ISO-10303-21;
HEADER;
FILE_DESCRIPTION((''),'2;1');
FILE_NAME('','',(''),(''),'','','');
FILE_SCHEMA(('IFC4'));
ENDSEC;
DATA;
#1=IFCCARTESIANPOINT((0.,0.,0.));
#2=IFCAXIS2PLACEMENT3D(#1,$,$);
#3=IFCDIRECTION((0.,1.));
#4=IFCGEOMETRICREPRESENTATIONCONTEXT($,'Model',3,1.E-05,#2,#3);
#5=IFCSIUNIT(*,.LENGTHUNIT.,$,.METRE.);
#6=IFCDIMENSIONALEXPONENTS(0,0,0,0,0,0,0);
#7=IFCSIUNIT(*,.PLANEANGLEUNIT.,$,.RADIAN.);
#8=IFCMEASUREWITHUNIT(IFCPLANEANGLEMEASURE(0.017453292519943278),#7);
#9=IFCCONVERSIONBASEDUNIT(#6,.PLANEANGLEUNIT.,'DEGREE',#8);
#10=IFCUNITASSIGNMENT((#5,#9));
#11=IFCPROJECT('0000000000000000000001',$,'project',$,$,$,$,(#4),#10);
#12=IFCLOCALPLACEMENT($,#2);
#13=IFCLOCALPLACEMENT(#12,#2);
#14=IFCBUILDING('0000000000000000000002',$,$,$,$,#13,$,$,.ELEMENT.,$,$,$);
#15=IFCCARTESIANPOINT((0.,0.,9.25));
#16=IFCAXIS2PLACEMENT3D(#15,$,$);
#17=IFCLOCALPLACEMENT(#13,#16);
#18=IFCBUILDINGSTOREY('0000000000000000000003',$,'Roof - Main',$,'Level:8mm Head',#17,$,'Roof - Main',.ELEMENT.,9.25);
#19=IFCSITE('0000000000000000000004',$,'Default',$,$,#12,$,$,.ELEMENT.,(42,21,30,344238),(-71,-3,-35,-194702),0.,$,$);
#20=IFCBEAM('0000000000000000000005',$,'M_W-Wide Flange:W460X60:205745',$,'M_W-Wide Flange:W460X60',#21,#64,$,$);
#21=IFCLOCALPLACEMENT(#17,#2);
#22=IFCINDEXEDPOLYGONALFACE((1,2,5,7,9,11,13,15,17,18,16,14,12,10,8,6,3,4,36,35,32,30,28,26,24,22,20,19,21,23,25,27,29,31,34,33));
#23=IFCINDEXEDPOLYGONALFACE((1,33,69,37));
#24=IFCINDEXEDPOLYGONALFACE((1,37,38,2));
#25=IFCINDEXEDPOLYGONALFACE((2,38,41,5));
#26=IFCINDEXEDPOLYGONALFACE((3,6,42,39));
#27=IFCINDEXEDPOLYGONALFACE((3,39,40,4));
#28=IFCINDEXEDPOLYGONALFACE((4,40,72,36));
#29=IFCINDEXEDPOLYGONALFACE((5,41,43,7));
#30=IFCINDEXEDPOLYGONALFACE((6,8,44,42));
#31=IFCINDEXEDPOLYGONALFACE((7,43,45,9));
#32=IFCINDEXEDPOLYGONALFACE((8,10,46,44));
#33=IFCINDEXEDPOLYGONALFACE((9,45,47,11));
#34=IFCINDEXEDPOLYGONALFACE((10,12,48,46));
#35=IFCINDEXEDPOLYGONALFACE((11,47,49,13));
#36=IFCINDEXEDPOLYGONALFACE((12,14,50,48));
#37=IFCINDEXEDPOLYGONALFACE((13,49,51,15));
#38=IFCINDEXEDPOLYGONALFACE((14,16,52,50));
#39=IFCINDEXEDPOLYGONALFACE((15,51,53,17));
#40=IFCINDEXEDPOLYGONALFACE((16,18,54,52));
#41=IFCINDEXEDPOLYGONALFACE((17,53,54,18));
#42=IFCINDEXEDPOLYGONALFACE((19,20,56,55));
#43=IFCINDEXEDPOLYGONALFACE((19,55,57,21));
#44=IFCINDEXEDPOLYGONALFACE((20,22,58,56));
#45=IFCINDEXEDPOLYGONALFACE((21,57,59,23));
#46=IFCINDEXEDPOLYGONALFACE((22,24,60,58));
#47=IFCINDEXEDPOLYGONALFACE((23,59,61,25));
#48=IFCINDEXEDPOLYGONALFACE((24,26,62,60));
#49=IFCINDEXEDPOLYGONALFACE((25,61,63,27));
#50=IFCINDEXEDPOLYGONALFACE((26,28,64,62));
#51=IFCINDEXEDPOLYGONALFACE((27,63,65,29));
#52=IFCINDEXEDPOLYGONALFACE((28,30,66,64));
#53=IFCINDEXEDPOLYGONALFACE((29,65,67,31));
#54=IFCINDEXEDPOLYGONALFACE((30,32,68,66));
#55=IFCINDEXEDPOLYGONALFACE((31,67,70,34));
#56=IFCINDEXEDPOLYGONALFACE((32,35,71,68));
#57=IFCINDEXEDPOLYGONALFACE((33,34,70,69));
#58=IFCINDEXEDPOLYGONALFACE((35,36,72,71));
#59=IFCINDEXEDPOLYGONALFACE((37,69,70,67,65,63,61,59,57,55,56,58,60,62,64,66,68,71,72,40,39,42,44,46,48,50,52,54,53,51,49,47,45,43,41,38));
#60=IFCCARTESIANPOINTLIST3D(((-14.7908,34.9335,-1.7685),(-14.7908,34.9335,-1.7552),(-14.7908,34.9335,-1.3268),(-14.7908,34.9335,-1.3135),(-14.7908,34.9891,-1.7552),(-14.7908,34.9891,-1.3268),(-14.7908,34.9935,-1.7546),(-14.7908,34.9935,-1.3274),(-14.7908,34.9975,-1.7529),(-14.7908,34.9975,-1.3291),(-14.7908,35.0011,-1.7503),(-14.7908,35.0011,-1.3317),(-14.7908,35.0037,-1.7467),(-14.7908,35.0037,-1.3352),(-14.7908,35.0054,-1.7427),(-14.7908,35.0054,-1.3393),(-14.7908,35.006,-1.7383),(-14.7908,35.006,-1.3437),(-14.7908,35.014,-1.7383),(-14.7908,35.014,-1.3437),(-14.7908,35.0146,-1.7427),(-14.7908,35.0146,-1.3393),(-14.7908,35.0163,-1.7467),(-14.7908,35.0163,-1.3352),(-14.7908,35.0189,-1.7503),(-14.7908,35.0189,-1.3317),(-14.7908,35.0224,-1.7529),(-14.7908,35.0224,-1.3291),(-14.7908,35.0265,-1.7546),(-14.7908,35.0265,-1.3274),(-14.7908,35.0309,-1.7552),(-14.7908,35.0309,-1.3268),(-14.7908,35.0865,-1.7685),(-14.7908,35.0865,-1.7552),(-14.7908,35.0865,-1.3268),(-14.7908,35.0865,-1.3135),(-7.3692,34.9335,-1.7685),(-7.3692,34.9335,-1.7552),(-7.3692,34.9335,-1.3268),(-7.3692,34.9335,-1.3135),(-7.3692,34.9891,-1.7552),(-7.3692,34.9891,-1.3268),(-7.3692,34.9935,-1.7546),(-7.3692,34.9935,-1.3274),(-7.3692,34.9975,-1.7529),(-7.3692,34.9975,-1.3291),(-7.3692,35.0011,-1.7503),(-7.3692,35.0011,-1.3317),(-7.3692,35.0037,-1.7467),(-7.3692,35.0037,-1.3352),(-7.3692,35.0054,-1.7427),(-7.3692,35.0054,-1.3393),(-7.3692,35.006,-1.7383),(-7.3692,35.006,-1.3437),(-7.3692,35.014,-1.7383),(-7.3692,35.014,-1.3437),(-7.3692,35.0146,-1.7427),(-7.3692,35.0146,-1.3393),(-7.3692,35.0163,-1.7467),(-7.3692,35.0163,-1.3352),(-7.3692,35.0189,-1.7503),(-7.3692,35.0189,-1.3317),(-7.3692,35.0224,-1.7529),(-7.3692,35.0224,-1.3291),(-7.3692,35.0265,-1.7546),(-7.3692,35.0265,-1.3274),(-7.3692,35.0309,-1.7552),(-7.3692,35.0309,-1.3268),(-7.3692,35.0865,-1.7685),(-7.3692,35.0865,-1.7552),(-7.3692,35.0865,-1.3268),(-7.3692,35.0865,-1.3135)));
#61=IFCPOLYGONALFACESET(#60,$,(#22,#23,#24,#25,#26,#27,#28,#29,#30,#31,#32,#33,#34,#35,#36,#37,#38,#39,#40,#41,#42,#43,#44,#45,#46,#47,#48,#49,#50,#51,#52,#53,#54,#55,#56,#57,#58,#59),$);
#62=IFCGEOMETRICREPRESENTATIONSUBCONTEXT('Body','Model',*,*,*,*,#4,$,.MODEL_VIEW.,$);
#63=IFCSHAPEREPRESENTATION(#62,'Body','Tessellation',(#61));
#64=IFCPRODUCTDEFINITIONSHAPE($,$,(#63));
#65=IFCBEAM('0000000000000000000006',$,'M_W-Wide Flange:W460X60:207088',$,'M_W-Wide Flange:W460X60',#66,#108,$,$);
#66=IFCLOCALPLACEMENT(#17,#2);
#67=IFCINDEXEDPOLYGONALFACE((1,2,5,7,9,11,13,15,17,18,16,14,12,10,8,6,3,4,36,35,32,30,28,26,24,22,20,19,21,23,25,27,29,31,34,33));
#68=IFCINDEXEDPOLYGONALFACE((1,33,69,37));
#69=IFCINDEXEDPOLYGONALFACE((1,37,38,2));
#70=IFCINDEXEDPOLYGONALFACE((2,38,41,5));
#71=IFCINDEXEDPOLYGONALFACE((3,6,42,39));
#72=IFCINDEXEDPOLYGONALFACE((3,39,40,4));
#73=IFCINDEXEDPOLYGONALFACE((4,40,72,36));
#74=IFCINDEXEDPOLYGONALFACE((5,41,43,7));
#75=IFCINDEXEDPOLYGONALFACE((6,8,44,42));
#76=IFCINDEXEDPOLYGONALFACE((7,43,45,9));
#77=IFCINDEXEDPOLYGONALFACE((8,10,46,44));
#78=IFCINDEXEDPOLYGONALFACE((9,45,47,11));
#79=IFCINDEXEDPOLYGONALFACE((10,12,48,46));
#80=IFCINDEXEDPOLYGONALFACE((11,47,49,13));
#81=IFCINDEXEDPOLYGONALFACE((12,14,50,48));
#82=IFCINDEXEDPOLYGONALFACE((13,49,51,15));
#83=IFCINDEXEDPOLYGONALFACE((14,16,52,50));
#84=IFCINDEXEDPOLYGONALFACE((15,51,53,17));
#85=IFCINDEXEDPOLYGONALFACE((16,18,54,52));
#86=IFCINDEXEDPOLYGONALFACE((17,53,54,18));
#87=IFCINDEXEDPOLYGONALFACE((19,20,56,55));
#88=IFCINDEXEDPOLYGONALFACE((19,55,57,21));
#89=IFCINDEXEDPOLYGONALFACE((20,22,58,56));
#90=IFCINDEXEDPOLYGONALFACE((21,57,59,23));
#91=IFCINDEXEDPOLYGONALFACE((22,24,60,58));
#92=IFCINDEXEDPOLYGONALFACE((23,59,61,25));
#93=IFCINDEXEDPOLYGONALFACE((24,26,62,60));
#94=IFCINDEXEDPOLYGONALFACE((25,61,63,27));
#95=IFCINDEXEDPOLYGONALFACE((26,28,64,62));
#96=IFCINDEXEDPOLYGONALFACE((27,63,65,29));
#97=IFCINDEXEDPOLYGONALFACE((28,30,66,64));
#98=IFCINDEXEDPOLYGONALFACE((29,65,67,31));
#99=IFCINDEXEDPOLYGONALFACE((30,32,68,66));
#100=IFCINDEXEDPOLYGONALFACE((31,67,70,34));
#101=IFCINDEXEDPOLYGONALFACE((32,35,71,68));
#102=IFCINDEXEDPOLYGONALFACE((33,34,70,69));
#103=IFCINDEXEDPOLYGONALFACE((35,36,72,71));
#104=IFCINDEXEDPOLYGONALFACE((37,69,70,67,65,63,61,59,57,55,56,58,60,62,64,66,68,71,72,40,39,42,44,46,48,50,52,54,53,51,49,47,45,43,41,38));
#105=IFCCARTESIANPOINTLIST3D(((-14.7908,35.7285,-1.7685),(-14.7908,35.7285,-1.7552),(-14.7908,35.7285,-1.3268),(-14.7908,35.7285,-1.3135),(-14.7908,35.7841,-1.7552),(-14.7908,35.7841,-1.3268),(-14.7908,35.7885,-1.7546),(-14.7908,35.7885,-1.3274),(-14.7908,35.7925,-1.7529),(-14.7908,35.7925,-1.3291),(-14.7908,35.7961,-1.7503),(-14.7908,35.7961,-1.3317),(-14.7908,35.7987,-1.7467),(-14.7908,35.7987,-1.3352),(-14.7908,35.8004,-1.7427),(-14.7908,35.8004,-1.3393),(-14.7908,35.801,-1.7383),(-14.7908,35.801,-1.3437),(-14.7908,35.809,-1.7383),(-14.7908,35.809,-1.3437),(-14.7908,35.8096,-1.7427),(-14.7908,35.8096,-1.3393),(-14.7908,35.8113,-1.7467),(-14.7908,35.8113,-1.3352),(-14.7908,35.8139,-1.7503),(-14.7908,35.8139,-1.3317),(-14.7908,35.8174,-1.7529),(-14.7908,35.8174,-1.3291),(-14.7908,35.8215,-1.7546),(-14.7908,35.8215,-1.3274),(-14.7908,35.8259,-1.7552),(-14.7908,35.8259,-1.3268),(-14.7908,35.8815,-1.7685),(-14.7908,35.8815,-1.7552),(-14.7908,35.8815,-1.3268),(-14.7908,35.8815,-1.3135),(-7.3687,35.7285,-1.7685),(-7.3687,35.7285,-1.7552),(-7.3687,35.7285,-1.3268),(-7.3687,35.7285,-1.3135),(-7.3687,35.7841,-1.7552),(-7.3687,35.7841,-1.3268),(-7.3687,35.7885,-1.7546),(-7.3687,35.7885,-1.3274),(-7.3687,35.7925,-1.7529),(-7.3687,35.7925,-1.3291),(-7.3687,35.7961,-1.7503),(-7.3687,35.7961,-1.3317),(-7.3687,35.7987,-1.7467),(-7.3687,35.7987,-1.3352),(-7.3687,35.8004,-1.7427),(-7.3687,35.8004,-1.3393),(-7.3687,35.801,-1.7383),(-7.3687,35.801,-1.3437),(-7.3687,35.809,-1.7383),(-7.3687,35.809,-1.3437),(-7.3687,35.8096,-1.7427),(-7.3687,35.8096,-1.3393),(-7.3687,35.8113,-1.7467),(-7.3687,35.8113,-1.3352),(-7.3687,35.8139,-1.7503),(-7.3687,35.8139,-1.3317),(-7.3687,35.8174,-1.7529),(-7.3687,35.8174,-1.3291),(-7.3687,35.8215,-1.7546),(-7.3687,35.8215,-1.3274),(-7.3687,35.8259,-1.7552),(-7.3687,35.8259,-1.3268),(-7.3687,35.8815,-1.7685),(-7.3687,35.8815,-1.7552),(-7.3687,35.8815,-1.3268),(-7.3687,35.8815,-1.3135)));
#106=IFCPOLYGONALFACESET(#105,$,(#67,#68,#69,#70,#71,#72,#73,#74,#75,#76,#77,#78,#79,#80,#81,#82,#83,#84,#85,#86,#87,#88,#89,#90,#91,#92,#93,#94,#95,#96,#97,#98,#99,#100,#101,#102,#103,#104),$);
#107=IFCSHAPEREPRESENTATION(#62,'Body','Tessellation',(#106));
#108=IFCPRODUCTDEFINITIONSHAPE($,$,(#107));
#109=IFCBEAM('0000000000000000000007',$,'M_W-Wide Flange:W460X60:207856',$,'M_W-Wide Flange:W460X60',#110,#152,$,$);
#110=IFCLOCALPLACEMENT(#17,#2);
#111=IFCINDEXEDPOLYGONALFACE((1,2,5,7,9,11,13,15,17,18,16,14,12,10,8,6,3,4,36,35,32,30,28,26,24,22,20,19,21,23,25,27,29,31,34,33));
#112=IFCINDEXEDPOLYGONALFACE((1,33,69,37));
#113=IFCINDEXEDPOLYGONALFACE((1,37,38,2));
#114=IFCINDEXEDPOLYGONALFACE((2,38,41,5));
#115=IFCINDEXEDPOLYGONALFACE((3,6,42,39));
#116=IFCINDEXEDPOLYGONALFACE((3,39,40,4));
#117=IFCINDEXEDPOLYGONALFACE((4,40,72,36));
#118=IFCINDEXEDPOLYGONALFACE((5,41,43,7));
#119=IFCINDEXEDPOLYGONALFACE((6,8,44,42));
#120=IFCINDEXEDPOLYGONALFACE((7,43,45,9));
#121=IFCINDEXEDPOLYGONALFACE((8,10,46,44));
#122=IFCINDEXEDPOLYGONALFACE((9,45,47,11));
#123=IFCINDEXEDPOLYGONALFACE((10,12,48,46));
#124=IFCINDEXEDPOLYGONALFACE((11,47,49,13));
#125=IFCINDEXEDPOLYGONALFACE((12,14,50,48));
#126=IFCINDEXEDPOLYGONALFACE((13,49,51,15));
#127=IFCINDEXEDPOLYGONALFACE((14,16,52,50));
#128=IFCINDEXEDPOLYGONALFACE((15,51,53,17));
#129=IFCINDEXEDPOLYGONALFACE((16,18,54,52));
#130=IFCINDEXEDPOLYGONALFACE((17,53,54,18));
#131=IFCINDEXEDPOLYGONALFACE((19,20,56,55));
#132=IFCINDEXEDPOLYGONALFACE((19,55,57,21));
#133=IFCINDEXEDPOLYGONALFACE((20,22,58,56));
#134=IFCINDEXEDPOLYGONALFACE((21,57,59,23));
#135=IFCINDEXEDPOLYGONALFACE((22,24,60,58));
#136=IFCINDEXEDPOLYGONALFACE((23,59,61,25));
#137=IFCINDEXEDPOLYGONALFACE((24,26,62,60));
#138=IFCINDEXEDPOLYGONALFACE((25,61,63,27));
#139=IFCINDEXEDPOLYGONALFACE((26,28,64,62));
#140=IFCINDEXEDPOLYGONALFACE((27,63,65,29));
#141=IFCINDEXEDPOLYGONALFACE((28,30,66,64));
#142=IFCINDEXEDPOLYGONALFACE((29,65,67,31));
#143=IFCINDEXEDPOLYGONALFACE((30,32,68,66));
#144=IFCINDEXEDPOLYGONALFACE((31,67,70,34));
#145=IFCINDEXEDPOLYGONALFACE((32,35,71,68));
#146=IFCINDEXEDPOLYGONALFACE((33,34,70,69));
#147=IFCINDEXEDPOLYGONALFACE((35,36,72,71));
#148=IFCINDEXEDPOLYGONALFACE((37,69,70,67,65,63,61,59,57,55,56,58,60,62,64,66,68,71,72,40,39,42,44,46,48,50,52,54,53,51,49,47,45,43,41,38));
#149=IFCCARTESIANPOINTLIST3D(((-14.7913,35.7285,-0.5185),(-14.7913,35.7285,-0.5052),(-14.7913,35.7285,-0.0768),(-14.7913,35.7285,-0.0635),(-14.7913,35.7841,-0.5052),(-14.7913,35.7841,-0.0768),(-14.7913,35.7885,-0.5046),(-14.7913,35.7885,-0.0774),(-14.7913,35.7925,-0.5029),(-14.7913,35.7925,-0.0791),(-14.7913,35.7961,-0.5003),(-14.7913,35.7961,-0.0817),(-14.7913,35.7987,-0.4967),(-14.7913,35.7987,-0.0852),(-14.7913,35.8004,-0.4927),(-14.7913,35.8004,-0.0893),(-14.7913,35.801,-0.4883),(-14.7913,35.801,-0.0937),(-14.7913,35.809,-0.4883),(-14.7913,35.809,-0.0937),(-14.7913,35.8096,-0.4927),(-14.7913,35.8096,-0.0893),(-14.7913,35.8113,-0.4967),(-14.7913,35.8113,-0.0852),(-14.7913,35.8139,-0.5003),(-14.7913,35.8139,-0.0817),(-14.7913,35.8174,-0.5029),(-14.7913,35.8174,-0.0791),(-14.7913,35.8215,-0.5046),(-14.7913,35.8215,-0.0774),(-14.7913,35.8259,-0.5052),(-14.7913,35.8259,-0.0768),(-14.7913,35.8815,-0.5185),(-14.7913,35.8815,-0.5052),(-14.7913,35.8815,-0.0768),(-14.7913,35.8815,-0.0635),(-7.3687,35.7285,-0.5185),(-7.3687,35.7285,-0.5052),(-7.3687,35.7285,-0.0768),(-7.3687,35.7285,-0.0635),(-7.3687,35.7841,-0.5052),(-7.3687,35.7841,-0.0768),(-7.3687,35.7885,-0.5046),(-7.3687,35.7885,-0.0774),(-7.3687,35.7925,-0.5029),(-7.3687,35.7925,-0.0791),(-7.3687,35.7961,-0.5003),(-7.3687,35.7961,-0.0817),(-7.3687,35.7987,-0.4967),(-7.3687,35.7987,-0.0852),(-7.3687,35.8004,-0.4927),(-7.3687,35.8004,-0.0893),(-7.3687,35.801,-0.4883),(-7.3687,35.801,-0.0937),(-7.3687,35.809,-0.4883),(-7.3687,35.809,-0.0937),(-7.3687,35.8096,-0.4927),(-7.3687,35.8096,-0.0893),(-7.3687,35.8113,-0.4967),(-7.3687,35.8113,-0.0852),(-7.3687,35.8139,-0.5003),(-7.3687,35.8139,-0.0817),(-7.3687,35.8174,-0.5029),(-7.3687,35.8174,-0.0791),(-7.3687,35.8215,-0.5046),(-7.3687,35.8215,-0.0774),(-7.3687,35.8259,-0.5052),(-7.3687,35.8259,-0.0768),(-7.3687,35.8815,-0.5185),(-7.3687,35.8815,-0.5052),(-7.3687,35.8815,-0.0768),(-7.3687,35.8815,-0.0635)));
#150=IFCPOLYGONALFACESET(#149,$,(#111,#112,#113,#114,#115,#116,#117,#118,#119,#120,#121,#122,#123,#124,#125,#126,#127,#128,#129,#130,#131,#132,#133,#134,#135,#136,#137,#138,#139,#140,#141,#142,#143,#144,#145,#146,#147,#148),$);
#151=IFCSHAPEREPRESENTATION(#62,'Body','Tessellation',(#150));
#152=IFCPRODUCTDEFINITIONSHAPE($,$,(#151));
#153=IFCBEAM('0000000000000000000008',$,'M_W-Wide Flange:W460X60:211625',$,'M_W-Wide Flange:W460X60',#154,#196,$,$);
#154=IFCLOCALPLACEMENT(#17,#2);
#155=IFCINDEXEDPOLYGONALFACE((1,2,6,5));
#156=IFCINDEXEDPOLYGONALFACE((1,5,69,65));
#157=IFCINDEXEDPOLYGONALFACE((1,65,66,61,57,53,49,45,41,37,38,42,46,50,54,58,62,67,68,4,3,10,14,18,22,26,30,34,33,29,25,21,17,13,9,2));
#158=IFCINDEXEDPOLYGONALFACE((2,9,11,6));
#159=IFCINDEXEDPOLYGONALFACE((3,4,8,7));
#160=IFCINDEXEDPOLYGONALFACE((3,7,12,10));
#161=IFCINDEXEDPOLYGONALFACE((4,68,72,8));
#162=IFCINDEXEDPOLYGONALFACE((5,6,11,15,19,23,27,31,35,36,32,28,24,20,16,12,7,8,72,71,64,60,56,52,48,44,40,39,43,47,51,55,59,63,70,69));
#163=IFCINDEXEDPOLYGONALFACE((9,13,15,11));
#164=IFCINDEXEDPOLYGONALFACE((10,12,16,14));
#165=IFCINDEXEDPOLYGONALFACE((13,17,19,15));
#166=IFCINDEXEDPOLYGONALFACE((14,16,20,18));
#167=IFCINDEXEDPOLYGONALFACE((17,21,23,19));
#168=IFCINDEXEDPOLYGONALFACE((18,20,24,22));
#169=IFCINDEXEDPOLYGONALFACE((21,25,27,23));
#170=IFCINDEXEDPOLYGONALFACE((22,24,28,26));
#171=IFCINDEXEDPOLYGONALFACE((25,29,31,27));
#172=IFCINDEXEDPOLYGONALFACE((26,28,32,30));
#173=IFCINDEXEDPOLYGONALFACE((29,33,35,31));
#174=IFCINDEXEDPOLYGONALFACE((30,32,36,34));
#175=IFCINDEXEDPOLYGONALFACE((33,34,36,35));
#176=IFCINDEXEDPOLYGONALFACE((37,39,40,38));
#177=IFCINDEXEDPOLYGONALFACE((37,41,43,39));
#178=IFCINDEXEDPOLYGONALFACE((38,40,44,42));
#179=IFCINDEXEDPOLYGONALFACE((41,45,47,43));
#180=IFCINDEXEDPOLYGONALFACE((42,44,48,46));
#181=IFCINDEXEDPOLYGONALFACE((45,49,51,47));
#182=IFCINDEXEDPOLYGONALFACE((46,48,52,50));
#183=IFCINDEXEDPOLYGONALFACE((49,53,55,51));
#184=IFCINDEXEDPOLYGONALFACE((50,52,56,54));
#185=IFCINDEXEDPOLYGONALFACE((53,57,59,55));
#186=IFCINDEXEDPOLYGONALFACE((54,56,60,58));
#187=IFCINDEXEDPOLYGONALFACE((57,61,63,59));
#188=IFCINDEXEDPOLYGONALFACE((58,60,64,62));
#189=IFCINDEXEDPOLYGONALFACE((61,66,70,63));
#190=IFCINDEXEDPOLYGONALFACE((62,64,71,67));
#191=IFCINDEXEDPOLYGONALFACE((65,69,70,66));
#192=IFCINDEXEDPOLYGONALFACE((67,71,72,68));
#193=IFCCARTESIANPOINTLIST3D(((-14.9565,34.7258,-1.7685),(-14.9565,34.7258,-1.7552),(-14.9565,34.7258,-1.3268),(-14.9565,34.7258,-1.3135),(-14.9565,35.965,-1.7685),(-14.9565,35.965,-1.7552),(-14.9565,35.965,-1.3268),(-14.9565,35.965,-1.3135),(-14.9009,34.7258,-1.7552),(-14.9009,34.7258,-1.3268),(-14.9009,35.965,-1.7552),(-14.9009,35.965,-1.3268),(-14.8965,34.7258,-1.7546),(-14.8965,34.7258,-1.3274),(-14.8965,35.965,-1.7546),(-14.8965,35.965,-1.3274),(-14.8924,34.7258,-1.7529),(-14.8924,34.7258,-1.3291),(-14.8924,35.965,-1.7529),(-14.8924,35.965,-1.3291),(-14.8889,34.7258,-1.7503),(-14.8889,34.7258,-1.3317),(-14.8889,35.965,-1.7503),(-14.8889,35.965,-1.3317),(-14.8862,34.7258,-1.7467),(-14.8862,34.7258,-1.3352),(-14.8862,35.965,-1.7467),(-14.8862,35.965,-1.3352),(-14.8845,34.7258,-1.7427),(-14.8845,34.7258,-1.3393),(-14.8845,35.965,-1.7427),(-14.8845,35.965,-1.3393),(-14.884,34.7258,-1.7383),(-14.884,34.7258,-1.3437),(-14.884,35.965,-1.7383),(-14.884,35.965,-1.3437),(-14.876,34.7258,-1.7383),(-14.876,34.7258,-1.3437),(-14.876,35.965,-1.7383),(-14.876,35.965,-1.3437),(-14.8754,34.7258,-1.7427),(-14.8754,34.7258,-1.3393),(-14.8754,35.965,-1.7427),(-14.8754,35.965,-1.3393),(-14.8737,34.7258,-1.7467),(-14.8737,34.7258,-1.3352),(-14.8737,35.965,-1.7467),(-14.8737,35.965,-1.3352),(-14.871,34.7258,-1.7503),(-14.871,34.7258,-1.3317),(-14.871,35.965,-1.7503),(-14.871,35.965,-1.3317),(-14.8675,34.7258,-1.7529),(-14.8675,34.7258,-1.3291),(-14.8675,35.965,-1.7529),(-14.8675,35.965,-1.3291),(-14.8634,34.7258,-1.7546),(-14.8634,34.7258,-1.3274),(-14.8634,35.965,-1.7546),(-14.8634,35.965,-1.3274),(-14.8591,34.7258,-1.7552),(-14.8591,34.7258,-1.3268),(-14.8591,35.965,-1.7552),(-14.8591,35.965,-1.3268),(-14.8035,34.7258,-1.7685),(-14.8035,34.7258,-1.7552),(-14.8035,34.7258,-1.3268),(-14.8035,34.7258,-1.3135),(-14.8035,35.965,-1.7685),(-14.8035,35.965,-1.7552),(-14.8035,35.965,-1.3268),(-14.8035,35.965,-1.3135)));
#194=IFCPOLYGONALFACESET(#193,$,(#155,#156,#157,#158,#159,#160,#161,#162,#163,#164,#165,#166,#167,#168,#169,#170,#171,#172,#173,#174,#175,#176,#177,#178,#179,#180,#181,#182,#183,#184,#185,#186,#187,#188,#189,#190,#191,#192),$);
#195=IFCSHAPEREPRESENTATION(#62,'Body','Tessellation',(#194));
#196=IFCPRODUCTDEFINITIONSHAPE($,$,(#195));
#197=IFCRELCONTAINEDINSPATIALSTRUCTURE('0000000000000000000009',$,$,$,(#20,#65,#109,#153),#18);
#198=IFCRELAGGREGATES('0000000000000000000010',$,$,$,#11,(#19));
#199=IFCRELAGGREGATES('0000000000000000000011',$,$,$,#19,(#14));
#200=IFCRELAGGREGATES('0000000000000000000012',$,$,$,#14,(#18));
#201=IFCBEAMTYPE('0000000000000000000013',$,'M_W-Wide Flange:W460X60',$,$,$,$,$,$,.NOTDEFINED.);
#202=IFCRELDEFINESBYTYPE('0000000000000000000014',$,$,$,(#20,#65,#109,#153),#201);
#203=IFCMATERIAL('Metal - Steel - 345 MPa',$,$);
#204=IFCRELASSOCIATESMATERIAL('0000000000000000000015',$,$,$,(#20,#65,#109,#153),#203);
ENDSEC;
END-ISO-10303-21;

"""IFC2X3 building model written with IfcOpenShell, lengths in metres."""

from ifc_helpers import new_model, entity, si_unit, converted_unit, direction, frame, frame_2d, origin, place, context, subcontext, project, spatial, i_section, extrude, material, type_object, element, save


model = new_model("IFC2X3")

# Units and contexts
model_context = context("Model", 3, precision=1e-05, world=origin(), true_north=direction((0.0, 1.0)))
body_context = subcontext(model_context, "Body", "Model", "MODEL_VIEW")
ifc_project = project(units=[si_unit("LENGTHUNIT", "METRE"), converted_unit("PLANEANGLEUNIT", "DEGREE", entity("IfcPlaneAngleMeasure", 0.017453292519943278), si_unit("PLANEANGLEUNIT", "RADIAN"), dimensions=[0, 0, 0, 0, 0, 0, 0])], contexts=[model_context])

# Site, building, storey
site_placement = place(None, origin())
site = spatial("IfcSite", under=ifc_project, at=site_placement, Name="Default", CompositionType="ELEMENT", RefLatitude=(42, 21, 30, 344238), RefLongitude=(-71, -3, -35, -194702), RefElevation=0.0)
building_placement = place(site_placement, origin())
building = spatial("IfcBuilding", under=site, at=building_placement, CompositionType="ELEMENT")
storey_placement = place(building_placement, frame((0.0, 0.0, 9.25)))
storey = spatial("IfcBuildingStorey", under=building, at=storey_placement, Name="Roof - Main", ObjectType="Level:8mm Head", LongName="Roof - Main", CompositionType="ELEMENT", Elevation=9.25)

# Shared definitions
ifc_material_1 = material(Name="Metal - Steel - 345 MPa")

# Beams
beam_type_1 = type_object("IfcBeamType", Name="M_W-Wide Flange:W460X60", PredefinedType="NOTDEFINED")
beam_1_placement = place(storey_placement, frame((-14.9, 35.01, -1.3135)))
element("IfcBeam", 1, at=beam_1_placement, inside=storey, type_object=beam_type_1, material=ifc_material_1, Name="M_W-Wide Flange:W460X60:205745", ObjectType="M_W-Wide Flange:W460X60", context=body_context, shape_type="SweptSolid", body=[
    extrude(i_section(OverallWidth=0.153, OverallDepth=0.455, WebThickness=0.008, FlangeThickness=0.0133, FilletRadius=0.0169, at=frame_2d((0.0, 0.0), x_axis=(0.0, 1.0))), frame((0.1092, 0.0, -0.2275), z_axis=(1.0, 0.0, 0.0), x_axis=(0.0, 0.0, -1.0)), (0.0, 0.0, 1.0), 7.4216),
])
beam_2_placement = place(storey_placement, frame((-14.88, 35.805, -1.3135)))
element("IfcBeam", 2, at=beam_2_placement, inside=storey, type_object=beam_type_1, material=ifc_material_1, Name="M_W-Wide Flange:W460X60:207088", ObjectType="M_W-Wide Flange:W460X60", context=body_context, shape_type="SweptSolid", body=[
    extrude(i_section(OverallWidth=0.153, OverallDepth=0.455, WebThickness=0.008, FlangeThickness=0.0133, FilletRadius=0.0169, at=frame_2d((0.0, 0.0), x_axis=(0.0, 1.0))), frame((0.0892, 0.0, -0.2275), z_axis=(1.0, 0.0, 0.0), x_axis=(0.0, 0.0, -1.0)), (0.0, 0.0, 1.0), 7.4221),
])
beam_3_placement = place(storey_placement, frame((-14.88, 35.805, -0.0635)))
element("IfcBeam", 3, at=beam_3_placement, inside=storey, type_object=beam_type_1, material=ifc_material_1, Name="M_W-Wide Flange:W460X60:207856", ObjectType="M_W-Wide Flange:W460X60", context=body_context, shape_type="SweptSolid", body=[
    extrude(i_section(OverallWidth=0.153, OverallDepth=0.455, WebThickness=0.008, FlangeThickness=0.0133, FilletRadius=0.0169, at=frame_2d((0.0, 0.0), x_axis=(0.0, 1.0))), frame((0.0887, 0.0, -0.2275), z_axis=(1.0, 0.0, 0.0), x_axis=(0.0, 0.0, -1.0)), (0.0, 0.0, 1.0), 7.4226),
])
beam_4_placement = place(storey_placement, frame((-14.88, 35.965, -1.3135), z_axis=(0.0, 0.0, 1.0), x_axis=(0.0, -1.0, 0.0)))
element("IfcBeam", 4, at=beam_4_placement, inside=storey, type_object=beam_type_1, material=ifc_material_1, Name="M_W-Wide Flange:W460X60:211625", ObjectType="M_W-Wide Flange:W460X60", context=body_context, shape_type="SweptSolid", body=[
    extrude(i_section(OverallWidth=0.153, OverallDepth=0.455, WebThickness=0.008, FlangeThickness=0.0133, FilletRadius=0.0169, at=frame_2d((0.0, 0.0), x_axis=(0.0, 1.0))), frame((0.0, 0.0, -0.2275), z_axis=(1.0, 0.0, 0.0), x_axis=(0.0, 0.0, -1.0)), (0.0, 0.0, 1.0), 1.2392),
])

save(model, "model.ifc")
